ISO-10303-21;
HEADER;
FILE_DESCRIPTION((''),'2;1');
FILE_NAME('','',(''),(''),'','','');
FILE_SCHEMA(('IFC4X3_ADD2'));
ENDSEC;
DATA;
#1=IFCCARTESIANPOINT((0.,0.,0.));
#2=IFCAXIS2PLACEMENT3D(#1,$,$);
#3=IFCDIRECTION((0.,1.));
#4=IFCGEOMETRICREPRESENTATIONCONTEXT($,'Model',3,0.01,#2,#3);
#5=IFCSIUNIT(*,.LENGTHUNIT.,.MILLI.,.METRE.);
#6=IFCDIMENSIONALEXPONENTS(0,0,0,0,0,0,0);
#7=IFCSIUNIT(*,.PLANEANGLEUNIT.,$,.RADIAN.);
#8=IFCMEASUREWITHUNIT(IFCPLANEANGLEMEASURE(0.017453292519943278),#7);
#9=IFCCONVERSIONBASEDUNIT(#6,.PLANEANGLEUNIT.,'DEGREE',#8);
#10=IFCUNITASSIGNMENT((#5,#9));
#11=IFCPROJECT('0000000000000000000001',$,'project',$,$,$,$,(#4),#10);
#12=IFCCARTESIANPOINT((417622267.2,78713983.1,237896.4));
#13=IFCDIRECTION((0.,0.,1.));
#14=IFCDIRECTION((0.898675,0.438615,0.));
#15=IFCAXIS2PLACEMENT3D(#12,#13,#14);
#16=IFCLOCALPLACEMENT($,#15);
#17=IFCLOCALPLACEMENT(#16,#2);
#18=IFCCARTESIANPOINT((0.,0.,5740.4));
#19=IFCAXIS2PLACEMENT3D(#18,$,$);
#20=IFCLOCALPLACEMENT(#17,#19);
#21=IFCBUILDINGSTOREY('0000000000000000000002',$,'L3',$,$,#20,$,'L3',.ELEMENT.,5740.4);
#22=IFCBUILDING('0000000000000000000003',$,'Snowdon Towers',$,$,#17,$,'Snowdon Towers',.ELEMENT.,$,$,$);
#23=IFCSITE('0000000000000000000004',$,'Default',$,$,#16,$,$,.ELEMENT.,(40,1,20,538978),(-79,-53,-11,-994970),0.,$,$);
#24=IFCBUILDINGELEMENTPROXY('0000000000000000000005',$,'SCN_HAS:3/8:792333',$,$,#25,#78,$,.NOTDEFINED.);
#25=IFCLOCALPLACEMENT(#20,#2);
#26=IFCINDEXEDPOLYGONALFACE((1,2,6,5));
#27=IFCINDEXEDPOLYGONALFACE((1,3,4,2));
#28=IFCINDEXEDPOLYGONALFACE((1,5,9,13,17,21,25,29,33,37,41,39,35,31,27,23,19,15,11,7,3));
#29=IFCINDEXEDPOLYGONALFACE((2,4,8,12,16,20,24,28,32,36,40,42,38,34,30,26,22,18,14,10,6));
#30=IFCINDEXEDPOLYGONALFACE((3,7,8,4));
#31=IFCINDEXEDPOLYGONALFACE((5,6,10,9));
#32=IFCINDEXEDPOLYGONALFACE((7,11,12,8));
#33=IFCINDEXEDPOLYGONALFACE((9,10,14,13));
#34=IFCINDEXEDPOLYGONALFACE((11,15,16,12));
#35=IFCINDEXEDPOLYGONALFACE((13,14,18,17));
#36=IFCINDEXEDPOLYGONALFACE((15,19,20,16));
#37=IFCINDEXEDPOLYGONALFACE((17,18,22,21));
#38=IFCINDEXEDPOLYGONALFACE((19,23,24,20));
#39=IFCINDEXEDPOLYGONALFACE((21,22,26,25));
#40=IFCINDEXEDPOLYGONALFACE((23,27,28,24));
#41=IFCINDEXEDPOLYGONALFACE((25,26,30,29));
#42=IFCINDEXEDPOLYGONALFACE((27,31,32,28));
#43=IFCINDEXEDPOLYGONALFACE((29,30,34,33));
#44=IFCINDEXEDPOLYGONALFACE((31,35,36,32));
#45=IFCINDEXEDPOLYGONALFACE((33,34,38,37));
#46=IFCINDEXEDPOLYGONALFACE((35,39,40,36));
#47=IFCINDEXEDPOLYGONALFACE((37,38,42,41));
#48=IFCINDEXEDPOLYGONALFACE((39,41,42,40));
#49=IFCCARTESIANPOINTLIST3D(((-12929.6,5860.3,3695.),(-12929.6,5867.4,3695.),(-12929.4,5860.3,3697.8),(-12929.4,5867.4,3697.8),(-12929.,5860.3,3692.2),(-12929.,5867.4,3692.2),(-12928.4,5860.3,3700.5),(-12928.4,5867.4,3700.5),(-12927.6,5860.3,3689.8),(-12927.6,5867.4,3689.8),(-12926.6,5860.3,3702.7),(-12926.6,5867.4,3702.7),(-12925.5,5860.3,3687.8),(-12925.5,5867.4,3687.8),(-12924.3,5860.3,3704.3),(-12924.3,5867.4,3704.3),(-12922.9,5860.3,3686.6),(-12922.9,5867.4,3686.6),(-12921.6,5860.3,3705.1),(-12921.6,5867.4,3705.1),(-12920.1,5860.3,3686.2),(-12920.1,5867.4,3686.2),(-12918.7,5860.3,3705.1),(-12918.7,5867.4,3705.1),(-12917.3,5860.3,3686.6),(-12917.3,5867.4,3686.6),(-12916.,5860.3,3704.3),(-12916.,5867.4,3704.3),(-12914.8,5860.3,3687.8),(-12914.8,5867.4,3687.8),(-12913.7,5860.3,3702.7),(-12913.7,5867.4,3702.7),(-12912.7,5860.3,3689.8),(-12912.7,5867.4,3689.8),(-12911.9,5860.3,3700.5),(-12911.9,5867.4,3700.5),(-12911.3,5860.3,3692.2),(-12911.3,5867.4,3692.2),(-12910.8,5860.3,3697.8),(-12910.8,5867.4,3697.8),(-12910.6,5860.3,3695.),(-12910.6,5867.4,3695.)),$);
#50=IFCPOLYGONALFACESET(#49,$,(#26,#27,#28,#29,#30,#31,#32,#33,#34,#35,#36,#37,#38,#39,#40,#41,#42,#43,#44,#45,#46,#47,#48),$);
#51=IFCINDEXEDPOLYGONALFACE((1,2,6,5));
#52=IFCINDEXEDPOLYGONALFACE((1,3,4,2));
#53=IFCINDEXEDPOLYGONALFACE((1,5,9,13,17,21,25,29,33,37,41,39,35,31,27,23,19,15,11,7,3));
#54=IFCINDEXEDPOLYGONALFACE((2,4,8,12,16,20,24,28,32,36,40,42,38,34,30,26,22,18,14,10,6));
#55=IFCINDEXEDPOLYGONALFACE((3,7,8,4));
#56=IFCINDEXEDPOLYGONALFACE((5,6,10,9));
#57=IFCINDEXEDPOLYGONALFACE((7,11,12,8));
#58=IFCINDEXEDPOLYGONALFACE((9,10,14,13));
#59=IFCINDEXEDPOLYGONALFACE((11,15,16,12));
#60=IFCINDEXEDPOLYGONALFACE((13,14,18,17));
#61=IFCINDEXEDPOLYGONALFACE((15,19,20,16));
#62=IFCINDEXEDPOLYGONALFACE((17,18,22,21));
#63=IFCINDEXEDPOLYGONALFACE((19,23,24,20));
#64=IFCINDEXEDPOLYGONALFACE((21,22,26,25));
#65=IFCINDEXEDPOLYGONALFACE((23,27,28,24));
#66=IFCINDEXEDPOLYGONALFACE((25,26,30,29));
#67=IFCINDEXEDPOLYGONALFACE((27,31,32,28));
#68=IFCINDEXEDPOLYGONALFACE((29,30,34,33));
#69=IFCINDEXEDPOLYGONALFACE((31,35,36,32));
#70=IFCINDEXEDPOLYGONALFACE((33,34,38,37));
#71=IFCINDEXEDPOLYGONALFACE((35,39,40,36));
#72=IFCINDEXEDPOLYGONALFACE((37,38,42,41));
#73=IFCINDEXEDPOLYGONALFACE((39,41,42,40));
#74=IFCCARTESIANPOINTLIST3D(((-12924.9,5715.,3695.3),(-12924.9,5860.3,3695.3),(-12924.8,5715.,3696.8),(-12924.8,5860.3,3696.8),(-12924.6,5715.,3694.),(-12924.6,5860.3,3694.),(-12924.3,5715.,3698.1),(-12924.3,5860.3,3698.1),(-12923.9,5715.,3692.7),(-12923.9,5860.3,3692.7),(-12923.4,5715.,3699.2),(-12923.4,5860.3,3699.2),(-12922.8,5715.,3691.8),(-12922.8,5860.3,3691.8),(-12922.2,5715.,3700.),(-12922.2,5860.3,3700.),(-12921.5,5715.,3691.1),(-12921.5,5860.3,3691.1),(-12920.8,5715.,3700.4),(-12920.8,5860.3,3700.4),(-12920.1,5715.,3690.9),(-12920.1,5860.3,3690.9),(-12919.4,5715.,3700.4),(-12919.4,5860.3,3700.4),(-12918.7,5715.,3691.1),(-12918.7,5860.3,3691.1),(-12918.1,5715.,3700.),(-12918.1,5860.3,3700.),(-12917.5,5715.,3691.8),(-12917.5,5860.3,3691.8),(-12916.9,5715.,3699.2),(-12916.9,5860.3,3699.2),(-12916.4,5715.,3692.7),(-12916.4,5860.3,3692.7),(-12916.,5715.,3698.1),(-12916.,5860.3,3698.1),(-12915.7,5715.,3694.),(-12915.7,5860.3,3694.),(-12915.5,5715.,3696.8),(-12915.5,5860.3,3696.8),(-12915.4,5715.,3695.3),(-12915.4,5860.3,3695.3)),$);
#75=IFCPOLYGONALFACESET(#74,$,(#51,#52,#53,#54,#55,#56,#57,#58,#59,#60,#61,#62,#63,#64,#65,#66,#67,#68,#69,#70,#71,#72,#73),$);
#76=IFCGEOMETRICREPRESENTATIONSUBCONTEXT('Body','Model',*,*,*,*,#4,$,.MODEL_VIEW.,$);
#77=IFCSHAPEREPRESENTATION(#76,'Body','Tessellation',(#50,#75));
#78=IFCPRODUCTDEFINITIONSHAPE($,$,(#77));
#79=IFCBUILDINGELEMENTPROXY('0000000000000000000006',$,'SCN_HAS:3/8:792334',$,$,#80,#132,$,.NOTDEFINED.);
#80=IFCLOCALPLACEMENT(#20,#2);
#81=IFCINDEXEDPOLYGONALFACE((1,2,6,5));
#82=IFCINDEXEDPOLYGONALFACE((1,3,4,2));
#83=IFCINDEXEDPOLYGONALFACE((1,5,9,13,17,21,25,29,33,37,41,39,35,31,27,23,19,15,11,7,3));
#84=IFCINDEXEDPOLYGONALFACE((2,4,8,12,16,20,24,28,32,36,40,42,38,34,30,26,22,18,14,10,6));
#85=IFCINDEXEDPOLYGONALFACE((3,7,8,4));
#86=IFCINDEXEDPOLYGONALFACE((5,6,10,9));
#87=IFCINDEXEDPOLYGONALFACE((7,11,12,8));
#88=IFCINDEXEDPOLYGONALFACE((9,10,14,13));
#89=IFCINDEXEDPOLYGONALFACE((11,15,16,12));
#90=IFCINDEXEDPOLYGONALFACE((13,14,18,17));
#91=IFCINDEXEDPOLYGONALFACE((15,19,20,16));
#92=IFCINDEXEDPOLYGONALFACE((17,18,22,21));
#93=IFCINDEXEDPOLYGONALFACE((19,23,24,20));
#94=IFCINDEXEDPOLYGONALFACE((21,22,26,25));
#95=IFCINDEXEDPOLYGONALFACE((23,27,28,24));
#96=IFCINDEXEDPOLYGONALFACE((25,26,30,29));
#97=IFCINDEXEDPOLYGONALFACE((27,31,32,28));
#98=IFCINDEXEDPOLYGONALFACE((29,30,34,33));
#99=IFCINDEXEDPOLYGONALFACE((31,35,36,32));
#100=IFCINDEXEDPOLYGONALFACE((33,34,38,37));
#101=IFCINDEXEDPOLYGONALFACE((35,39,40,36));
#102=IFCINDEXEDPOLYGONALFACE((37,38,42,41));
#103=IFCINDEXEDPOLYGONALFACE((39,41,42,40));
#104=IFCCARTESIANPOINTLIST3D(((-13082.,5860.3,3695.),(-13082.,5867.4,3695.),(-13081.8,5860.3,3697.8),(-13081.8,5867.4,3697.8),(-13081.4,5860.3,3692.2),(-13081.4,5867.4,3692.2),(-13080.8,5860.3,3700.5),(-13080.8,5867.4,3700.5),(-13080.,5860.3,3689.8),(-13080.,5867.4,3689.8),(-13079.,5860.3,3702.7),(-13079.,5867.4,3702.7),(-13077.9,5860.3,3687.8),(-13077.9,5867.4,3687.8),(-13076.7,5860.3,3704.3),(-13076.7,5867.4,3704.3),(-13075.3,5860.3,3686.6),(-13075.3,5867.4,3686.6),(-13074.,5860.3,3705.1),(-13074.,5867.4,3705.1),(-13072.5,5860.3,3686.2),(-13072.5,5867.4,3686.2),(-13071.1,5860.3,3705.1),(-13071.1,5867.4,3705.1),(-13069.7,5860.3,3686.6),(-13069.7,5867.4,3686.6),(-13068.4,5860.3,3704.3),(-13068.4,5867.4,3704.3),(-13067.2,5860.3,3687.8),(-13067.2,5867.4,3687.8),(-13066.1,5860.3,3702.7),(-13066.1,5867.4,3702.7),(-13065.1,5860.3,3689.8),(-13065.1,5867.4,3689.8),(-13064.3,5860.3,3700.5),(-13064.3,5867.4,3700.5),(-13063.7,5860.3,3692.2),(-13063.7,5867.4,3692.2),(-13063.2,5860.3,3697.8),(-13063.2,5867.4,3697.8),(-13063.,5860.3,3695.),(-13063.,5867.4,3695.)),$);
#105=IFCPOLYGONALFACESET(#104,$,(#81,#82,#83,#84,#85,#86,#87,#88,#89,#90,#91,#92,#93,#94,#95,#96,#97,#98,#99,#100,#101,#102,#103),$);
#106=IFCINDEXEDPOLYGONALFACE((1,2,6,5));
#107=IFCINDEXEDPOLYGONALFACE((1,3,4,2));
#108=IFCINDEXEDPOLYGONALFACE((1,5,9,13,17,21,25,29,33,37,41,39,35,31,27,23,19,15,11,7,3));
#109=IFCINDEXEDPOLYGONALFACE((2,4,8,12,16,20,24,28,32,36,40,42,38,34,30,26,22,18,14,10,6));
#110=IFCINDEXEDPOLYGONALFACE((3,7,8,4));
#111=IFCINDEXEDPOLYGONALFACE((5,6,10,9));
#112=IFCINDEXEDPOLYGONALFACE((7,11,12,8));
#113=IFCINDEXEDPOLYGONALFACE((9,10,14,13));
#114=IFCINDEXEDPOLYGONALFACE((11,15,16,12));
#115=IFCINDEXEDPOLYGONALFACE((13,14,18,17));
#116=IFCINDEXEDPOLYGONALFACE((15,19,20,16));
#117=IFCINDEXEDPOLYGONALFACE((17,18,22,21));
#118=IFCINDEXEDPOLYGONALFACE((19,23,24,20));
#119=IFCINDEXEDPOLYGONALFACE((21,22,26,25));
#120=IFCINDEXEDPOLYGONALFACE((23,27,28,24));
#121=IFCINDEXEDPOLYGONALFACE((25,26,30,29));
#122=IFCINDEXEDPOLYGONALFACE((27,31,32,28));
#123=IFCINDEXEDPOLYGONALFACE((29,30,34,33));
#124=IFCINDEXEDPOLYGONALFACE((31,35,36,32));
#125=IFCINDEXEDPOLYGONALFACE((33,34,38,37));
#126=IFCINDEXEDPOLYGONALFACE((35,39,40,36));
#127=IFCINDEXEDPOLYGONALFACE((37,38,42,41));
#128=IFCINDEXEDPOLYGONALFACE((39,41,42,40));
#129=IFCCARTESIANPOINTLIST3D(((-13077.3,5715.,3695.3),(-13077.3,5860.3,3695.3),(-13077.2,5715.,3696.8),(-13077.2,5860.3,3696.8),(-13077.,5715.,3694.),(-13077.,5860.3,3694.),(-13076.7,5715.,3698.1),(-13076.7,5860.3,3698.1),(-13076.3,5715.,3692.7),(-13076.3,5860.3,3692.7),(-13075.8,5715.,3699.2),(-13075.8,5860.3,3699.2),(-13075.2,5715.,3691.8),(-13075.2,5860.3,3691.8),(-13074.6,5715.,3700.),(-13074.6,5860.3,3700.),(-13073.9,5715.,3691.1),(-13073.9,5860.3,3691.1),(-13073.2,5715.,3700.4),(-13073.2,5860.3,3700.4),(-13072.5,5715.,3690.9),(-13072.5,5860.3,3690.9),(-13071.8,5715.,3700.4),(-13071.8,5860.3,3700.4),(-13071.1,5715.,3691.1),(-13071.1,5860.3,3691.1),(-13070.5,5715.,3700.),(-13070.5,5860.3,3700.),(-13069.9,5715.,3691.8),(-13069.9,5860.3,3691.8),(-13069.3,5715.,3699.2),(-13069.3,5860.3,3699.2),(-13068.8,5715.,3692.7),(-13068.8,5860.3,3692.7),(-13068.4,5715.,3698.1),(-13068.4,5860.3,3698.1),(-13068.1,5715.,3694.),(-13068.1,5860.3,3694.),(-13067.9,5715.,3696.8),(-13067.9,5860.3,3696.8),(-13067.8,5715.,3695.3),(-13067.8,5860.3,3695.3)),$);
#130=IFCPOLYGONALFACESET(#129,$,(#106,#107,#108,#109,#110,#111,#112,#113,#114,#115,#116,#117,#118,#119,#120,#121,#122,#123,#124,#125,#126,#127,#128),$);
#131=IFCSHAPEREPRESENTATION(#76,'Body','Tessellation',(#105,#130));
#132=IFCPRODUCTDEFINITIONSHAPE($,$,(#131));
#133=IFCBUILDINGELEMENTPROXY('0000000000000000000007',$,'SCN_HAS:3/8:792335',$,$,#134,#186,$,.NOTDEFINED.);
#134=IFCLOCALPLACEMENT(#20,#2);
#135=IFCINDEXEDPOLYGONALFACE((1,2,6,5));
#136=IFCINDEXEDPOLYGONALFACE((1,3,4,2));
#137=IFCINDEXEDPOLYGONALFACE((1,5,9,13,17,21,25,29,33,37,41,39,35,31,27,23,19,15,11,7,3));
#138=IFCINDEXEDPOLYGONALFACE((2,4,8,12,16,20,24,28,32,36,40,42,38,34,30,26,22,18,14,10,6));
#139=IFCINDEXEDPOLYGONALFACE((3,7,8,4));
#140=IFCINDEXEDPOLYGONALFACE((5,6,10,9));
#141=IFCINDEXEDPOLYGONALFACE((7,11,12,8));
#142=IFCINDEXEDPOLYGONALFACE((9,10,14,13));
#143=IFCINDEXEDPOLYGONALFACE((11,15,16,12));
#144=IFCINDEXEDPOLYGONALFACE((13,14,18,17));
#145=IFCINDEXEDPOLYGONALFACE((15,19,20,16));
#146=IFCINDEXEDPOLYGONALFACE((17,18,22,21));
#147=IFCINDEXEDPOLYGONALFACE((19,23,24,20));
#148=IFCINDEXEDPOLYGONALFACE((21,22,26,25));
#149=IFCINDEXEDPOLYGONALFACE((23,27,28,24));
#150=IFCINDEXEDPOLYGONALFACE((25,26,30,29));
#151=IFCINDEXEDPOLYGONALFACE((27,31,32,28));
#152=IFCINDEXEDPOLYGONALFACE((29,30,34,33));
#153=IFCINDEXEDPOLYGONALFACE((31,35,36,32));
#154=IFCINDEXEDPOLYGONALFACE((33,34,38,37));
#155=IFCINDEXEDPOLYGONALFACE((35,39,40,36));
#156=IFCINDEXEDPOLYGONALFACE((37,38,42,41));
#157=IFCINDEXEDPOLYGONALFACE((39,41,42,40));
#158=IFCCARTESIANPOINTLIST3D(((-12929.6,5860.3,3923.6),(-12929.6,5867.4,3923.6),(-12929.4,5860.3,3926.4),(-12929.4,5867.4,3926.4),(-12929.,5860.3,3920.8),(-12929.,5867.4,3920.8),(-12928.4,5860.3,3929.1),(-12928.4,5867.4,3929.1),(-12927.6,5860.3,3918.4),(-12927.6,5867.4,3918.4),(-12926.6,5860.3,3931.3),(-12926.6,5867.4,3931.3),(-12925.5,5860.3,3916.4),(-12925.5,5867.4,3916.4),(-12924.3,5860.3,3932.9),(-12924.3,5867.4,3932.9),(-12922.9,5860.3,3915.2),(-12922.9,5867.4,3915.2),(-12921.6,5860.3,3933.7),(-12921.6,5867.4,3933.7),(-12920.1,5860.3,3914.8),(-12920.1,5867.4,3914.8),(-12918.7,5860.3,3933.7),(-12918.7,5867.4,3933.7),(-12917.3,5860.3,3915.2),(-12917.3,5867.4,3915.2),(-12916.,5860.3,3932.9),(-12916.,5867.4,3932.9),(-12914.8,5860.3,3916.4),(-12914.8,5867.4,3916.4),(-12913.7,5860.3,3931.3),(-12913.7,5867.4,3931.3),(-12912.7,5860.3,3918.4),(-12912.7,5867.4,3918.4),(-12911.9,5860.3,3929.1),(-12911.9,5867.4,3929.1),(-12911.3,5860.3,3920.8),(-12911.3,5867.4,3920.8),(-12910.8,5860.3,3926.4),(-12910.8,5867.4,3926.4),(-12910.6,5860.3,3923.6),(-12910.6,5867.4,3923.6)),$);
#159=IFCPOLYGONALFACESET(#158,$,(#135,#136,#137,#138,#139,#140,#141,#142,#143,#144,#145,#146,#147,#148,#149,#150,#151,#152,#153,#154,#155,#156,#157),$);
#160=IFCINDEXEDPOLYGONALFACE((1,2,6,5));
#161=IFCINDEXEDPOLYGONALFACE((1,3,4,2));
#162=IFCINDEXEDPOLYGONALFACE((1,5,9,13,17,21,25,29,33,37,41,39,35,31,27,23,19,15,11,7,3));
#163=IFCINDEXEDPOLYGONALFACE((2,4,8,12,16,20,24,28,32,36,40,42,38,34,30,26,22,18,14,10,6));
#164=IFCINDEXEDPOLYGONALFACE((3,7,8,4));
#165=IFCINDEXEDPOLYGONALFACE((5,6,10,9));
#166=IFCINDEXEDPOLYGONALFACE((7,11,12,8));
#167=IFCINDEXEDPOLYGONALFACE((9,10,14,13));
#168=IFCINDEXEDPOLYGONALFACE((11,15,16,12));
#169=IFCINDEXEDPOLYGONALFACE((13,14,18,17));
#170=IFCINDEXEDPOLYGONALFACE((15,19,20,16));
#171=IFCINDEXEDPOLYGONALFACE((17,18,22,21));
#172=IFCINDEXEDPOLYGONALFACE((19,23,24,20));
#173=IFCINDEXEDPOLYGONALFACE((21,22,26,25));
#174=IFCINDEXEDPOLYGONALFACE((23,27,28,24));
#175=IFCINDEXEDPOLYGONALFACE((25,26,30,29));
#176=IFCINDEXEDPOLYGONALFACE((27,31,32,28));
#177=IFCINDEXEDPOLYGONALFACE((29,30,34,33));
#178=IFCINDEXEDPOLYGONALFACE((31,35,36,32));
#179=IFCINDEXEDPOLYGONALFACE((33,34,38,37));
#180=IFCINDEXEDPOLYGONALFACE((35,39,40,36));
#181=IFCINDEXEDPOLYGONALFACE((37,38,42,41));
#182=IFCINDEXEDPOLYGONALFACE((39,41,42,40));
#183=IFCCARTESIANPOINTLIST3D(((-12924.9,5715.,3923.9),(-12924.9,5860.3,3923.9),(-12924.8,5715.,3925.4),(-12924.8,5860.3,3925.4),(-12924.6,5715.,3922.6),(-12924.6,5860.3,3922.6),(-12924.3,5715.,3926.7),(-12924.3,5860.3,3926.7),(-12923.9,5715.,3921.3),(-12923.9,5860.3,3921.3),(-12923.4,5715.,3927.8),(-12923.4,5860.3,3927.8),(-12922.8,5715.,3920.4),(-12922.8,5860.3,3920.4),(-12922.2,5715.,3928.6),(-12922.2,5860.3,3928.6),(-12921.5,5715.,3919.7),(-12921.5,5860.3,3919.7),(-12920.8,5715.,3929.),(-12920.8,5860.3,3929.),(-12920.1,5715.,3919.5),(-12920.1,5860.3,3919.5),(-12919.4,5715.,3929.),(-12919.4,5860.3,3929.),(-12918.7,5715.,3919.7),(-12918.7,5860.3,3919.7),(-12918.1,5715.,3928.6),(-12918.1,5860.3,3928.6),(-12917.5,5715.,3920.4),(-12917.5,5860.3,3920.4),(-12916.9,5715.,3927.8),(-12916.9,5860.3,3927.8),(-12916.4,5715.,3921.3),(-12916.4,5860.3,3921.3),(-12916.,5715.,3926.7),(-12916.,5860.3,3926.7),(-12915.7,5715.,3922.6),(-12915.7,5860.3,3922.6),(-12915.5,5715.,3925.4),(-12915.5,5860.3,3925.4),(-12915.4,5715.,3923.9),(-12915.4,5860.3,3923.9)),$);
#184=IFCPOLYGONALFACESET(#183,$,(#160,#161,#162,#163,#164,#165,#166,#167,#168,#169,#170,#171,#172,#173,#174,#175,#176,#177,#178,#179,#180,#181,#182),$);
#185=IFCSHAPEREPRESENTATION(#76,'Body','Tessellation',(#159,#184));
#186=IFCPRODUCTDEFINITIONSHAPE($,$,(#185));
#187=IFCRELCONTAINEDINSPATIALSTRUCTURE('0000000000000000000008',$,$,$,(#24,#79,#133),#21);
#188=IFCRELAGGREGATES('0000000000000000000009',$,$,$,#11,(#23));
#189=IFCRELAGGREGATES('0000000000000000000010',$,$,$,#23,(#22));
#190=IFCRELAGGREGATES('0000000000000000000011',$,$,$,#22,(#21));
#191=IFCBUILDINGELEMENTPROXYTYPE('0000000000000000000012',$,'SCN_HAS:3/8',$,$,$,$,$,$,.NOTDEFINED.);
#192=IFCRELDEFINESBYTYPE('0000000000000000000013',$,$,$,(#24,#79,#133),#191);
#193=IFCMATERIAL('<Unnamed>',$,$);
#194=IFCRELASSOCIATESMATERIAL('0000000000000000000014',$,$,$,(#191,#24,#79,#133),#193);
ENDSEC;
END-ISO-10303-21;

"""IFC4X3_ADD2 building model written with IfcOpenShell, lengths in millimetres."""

from ifc_helpers import new_model, entity, si_unit, converted_unit, direction, frame, frame_2d, origin, place, context, subcontext, project, spatial, circle, extrude, source, transform, mapped, material, type_object, type_shapes, element, save


model = new_model("IFC4X3_ADD2")

# Units and contexts
model_context = context("Model", 3, precision=0.01, world=origin(), true_north=direction((0.0, 1.0)))
body_context = subcontext(model_context, "Body", "Model", "MODEL_VIEW")
ifc_project = project(units=[si_unit("LENGTHUNIT", "METRE", prefix="MILLI"), converted_unit("PLANEANGLEUNIT", "DEGREE", entity("IfcPlaneAngleMeasure", 0.017453292519943278), si_unit("PLANEANGLEUNIT", "RADIAN"), dimensions=[0, 0, 0, 0, 0, 0, 0])], contexts=[model_context])

# Site, building, storey
site_placement = place(None, frame((417622267.2, 78713983.1, 237896.4), z_axis=(0.0, 0.0, 1.0), x_axis=(0.898675, 0.438615, 0.0)))
site = spatial("IfcSite", under=ifc_project, at=site_placement, Name="Default", CompositionType="ELEMENT", RefLatitude=(40, 1, 20, 538978), RefLongitude=(-79, -53, -11, -994970), RefElevation=0.0)
building_placement = place(site_placement, origin())
building = spatial("IfcBuilding", under=site, at=building_placement, Name="Snowdon Towers", LongName="Snowdon Towers", CompositionType="ELEMENT")
storey_placement = place(building_placement, frame((0.0, 0.0, 5740.4)))
storey = spatial("IfcBuildingStorey", under=building, at=storey_placement, Name="L3", LongName="L3", CompositionType="ELEMENT", Elevation=5740.4)

# Building element proxies
ifc_material_1 = material(Name="<Unnamed>")
building_element_proxy_type_1 = type_object("IfcBuildingElementProxyType", Name="SCN_HAS:3/8", PredefinedType="NOTDEFINED", material=ifc_material_1)
shared_shape_1 = source(origin(), body_context, "Body", "SweptSolid", [
    extrude(circle(Radius=9.5, at=frame_2d((0.0, 0.0), x_axis=(1.0, 0.0))), frame((0.0, 0.0, -152.4), z_axis=(0.0, 0.0, 1.0), x_axis=(0.0, -1.0, 0.0)), (0.0, 0.0, 1.0), 7.1),
    extrude(circle(Radius=4.8, at=frame_2d((0.0, 0.0), x_axis=(1.0, 0.0))), frame((0.0, 0.0, -145.3), z_axis=(0.0, 0.0, 1.0), x_axis=(0.0, -1.0, 0.0)), (0.0, 0.0, 1.0), 145.3),
])
type_shapes(building_element_proxy_type_1, [shared_shape_1])
for number, where, z_axis, x_axis, name in (
    (1, (-12920.1, 5715.0, 3695.7), (0.0, -1.0, 0.0), (1.0, 0.0, 0.0), "SCN_HAS:3/8:792333"),
    (2, (-13072.5, 5715.0, 3695.7), (0.0, -1.0, 0.0), (1.0, 0.0, 0.0), "SCN_HAS:3/8:792334"),
    (3, (-12920.1, 5715.0, 3924.3), (0.0, -1.0, 0.0), (1.0, 0.0, 0.0), "SCN_HAS:3/8:792335"),
):
    element("IfcBuildingElementProxy", number, at=place(storey_placement, frame(where, z_axis=z_axis, x_axis=x_axis)), inside=storey, type_object=building_element_proxy_type_1, material=ifc_material_1, Name=name, PredefinedType="NOTDEFINED", context=body_context, shape_type="MappedRepresentation", body=[
        mapped(shared_shape_1, transform((0.0, 0.0, 0.0), scale=1.0)),
    ])

save(model, "model.ifc")
